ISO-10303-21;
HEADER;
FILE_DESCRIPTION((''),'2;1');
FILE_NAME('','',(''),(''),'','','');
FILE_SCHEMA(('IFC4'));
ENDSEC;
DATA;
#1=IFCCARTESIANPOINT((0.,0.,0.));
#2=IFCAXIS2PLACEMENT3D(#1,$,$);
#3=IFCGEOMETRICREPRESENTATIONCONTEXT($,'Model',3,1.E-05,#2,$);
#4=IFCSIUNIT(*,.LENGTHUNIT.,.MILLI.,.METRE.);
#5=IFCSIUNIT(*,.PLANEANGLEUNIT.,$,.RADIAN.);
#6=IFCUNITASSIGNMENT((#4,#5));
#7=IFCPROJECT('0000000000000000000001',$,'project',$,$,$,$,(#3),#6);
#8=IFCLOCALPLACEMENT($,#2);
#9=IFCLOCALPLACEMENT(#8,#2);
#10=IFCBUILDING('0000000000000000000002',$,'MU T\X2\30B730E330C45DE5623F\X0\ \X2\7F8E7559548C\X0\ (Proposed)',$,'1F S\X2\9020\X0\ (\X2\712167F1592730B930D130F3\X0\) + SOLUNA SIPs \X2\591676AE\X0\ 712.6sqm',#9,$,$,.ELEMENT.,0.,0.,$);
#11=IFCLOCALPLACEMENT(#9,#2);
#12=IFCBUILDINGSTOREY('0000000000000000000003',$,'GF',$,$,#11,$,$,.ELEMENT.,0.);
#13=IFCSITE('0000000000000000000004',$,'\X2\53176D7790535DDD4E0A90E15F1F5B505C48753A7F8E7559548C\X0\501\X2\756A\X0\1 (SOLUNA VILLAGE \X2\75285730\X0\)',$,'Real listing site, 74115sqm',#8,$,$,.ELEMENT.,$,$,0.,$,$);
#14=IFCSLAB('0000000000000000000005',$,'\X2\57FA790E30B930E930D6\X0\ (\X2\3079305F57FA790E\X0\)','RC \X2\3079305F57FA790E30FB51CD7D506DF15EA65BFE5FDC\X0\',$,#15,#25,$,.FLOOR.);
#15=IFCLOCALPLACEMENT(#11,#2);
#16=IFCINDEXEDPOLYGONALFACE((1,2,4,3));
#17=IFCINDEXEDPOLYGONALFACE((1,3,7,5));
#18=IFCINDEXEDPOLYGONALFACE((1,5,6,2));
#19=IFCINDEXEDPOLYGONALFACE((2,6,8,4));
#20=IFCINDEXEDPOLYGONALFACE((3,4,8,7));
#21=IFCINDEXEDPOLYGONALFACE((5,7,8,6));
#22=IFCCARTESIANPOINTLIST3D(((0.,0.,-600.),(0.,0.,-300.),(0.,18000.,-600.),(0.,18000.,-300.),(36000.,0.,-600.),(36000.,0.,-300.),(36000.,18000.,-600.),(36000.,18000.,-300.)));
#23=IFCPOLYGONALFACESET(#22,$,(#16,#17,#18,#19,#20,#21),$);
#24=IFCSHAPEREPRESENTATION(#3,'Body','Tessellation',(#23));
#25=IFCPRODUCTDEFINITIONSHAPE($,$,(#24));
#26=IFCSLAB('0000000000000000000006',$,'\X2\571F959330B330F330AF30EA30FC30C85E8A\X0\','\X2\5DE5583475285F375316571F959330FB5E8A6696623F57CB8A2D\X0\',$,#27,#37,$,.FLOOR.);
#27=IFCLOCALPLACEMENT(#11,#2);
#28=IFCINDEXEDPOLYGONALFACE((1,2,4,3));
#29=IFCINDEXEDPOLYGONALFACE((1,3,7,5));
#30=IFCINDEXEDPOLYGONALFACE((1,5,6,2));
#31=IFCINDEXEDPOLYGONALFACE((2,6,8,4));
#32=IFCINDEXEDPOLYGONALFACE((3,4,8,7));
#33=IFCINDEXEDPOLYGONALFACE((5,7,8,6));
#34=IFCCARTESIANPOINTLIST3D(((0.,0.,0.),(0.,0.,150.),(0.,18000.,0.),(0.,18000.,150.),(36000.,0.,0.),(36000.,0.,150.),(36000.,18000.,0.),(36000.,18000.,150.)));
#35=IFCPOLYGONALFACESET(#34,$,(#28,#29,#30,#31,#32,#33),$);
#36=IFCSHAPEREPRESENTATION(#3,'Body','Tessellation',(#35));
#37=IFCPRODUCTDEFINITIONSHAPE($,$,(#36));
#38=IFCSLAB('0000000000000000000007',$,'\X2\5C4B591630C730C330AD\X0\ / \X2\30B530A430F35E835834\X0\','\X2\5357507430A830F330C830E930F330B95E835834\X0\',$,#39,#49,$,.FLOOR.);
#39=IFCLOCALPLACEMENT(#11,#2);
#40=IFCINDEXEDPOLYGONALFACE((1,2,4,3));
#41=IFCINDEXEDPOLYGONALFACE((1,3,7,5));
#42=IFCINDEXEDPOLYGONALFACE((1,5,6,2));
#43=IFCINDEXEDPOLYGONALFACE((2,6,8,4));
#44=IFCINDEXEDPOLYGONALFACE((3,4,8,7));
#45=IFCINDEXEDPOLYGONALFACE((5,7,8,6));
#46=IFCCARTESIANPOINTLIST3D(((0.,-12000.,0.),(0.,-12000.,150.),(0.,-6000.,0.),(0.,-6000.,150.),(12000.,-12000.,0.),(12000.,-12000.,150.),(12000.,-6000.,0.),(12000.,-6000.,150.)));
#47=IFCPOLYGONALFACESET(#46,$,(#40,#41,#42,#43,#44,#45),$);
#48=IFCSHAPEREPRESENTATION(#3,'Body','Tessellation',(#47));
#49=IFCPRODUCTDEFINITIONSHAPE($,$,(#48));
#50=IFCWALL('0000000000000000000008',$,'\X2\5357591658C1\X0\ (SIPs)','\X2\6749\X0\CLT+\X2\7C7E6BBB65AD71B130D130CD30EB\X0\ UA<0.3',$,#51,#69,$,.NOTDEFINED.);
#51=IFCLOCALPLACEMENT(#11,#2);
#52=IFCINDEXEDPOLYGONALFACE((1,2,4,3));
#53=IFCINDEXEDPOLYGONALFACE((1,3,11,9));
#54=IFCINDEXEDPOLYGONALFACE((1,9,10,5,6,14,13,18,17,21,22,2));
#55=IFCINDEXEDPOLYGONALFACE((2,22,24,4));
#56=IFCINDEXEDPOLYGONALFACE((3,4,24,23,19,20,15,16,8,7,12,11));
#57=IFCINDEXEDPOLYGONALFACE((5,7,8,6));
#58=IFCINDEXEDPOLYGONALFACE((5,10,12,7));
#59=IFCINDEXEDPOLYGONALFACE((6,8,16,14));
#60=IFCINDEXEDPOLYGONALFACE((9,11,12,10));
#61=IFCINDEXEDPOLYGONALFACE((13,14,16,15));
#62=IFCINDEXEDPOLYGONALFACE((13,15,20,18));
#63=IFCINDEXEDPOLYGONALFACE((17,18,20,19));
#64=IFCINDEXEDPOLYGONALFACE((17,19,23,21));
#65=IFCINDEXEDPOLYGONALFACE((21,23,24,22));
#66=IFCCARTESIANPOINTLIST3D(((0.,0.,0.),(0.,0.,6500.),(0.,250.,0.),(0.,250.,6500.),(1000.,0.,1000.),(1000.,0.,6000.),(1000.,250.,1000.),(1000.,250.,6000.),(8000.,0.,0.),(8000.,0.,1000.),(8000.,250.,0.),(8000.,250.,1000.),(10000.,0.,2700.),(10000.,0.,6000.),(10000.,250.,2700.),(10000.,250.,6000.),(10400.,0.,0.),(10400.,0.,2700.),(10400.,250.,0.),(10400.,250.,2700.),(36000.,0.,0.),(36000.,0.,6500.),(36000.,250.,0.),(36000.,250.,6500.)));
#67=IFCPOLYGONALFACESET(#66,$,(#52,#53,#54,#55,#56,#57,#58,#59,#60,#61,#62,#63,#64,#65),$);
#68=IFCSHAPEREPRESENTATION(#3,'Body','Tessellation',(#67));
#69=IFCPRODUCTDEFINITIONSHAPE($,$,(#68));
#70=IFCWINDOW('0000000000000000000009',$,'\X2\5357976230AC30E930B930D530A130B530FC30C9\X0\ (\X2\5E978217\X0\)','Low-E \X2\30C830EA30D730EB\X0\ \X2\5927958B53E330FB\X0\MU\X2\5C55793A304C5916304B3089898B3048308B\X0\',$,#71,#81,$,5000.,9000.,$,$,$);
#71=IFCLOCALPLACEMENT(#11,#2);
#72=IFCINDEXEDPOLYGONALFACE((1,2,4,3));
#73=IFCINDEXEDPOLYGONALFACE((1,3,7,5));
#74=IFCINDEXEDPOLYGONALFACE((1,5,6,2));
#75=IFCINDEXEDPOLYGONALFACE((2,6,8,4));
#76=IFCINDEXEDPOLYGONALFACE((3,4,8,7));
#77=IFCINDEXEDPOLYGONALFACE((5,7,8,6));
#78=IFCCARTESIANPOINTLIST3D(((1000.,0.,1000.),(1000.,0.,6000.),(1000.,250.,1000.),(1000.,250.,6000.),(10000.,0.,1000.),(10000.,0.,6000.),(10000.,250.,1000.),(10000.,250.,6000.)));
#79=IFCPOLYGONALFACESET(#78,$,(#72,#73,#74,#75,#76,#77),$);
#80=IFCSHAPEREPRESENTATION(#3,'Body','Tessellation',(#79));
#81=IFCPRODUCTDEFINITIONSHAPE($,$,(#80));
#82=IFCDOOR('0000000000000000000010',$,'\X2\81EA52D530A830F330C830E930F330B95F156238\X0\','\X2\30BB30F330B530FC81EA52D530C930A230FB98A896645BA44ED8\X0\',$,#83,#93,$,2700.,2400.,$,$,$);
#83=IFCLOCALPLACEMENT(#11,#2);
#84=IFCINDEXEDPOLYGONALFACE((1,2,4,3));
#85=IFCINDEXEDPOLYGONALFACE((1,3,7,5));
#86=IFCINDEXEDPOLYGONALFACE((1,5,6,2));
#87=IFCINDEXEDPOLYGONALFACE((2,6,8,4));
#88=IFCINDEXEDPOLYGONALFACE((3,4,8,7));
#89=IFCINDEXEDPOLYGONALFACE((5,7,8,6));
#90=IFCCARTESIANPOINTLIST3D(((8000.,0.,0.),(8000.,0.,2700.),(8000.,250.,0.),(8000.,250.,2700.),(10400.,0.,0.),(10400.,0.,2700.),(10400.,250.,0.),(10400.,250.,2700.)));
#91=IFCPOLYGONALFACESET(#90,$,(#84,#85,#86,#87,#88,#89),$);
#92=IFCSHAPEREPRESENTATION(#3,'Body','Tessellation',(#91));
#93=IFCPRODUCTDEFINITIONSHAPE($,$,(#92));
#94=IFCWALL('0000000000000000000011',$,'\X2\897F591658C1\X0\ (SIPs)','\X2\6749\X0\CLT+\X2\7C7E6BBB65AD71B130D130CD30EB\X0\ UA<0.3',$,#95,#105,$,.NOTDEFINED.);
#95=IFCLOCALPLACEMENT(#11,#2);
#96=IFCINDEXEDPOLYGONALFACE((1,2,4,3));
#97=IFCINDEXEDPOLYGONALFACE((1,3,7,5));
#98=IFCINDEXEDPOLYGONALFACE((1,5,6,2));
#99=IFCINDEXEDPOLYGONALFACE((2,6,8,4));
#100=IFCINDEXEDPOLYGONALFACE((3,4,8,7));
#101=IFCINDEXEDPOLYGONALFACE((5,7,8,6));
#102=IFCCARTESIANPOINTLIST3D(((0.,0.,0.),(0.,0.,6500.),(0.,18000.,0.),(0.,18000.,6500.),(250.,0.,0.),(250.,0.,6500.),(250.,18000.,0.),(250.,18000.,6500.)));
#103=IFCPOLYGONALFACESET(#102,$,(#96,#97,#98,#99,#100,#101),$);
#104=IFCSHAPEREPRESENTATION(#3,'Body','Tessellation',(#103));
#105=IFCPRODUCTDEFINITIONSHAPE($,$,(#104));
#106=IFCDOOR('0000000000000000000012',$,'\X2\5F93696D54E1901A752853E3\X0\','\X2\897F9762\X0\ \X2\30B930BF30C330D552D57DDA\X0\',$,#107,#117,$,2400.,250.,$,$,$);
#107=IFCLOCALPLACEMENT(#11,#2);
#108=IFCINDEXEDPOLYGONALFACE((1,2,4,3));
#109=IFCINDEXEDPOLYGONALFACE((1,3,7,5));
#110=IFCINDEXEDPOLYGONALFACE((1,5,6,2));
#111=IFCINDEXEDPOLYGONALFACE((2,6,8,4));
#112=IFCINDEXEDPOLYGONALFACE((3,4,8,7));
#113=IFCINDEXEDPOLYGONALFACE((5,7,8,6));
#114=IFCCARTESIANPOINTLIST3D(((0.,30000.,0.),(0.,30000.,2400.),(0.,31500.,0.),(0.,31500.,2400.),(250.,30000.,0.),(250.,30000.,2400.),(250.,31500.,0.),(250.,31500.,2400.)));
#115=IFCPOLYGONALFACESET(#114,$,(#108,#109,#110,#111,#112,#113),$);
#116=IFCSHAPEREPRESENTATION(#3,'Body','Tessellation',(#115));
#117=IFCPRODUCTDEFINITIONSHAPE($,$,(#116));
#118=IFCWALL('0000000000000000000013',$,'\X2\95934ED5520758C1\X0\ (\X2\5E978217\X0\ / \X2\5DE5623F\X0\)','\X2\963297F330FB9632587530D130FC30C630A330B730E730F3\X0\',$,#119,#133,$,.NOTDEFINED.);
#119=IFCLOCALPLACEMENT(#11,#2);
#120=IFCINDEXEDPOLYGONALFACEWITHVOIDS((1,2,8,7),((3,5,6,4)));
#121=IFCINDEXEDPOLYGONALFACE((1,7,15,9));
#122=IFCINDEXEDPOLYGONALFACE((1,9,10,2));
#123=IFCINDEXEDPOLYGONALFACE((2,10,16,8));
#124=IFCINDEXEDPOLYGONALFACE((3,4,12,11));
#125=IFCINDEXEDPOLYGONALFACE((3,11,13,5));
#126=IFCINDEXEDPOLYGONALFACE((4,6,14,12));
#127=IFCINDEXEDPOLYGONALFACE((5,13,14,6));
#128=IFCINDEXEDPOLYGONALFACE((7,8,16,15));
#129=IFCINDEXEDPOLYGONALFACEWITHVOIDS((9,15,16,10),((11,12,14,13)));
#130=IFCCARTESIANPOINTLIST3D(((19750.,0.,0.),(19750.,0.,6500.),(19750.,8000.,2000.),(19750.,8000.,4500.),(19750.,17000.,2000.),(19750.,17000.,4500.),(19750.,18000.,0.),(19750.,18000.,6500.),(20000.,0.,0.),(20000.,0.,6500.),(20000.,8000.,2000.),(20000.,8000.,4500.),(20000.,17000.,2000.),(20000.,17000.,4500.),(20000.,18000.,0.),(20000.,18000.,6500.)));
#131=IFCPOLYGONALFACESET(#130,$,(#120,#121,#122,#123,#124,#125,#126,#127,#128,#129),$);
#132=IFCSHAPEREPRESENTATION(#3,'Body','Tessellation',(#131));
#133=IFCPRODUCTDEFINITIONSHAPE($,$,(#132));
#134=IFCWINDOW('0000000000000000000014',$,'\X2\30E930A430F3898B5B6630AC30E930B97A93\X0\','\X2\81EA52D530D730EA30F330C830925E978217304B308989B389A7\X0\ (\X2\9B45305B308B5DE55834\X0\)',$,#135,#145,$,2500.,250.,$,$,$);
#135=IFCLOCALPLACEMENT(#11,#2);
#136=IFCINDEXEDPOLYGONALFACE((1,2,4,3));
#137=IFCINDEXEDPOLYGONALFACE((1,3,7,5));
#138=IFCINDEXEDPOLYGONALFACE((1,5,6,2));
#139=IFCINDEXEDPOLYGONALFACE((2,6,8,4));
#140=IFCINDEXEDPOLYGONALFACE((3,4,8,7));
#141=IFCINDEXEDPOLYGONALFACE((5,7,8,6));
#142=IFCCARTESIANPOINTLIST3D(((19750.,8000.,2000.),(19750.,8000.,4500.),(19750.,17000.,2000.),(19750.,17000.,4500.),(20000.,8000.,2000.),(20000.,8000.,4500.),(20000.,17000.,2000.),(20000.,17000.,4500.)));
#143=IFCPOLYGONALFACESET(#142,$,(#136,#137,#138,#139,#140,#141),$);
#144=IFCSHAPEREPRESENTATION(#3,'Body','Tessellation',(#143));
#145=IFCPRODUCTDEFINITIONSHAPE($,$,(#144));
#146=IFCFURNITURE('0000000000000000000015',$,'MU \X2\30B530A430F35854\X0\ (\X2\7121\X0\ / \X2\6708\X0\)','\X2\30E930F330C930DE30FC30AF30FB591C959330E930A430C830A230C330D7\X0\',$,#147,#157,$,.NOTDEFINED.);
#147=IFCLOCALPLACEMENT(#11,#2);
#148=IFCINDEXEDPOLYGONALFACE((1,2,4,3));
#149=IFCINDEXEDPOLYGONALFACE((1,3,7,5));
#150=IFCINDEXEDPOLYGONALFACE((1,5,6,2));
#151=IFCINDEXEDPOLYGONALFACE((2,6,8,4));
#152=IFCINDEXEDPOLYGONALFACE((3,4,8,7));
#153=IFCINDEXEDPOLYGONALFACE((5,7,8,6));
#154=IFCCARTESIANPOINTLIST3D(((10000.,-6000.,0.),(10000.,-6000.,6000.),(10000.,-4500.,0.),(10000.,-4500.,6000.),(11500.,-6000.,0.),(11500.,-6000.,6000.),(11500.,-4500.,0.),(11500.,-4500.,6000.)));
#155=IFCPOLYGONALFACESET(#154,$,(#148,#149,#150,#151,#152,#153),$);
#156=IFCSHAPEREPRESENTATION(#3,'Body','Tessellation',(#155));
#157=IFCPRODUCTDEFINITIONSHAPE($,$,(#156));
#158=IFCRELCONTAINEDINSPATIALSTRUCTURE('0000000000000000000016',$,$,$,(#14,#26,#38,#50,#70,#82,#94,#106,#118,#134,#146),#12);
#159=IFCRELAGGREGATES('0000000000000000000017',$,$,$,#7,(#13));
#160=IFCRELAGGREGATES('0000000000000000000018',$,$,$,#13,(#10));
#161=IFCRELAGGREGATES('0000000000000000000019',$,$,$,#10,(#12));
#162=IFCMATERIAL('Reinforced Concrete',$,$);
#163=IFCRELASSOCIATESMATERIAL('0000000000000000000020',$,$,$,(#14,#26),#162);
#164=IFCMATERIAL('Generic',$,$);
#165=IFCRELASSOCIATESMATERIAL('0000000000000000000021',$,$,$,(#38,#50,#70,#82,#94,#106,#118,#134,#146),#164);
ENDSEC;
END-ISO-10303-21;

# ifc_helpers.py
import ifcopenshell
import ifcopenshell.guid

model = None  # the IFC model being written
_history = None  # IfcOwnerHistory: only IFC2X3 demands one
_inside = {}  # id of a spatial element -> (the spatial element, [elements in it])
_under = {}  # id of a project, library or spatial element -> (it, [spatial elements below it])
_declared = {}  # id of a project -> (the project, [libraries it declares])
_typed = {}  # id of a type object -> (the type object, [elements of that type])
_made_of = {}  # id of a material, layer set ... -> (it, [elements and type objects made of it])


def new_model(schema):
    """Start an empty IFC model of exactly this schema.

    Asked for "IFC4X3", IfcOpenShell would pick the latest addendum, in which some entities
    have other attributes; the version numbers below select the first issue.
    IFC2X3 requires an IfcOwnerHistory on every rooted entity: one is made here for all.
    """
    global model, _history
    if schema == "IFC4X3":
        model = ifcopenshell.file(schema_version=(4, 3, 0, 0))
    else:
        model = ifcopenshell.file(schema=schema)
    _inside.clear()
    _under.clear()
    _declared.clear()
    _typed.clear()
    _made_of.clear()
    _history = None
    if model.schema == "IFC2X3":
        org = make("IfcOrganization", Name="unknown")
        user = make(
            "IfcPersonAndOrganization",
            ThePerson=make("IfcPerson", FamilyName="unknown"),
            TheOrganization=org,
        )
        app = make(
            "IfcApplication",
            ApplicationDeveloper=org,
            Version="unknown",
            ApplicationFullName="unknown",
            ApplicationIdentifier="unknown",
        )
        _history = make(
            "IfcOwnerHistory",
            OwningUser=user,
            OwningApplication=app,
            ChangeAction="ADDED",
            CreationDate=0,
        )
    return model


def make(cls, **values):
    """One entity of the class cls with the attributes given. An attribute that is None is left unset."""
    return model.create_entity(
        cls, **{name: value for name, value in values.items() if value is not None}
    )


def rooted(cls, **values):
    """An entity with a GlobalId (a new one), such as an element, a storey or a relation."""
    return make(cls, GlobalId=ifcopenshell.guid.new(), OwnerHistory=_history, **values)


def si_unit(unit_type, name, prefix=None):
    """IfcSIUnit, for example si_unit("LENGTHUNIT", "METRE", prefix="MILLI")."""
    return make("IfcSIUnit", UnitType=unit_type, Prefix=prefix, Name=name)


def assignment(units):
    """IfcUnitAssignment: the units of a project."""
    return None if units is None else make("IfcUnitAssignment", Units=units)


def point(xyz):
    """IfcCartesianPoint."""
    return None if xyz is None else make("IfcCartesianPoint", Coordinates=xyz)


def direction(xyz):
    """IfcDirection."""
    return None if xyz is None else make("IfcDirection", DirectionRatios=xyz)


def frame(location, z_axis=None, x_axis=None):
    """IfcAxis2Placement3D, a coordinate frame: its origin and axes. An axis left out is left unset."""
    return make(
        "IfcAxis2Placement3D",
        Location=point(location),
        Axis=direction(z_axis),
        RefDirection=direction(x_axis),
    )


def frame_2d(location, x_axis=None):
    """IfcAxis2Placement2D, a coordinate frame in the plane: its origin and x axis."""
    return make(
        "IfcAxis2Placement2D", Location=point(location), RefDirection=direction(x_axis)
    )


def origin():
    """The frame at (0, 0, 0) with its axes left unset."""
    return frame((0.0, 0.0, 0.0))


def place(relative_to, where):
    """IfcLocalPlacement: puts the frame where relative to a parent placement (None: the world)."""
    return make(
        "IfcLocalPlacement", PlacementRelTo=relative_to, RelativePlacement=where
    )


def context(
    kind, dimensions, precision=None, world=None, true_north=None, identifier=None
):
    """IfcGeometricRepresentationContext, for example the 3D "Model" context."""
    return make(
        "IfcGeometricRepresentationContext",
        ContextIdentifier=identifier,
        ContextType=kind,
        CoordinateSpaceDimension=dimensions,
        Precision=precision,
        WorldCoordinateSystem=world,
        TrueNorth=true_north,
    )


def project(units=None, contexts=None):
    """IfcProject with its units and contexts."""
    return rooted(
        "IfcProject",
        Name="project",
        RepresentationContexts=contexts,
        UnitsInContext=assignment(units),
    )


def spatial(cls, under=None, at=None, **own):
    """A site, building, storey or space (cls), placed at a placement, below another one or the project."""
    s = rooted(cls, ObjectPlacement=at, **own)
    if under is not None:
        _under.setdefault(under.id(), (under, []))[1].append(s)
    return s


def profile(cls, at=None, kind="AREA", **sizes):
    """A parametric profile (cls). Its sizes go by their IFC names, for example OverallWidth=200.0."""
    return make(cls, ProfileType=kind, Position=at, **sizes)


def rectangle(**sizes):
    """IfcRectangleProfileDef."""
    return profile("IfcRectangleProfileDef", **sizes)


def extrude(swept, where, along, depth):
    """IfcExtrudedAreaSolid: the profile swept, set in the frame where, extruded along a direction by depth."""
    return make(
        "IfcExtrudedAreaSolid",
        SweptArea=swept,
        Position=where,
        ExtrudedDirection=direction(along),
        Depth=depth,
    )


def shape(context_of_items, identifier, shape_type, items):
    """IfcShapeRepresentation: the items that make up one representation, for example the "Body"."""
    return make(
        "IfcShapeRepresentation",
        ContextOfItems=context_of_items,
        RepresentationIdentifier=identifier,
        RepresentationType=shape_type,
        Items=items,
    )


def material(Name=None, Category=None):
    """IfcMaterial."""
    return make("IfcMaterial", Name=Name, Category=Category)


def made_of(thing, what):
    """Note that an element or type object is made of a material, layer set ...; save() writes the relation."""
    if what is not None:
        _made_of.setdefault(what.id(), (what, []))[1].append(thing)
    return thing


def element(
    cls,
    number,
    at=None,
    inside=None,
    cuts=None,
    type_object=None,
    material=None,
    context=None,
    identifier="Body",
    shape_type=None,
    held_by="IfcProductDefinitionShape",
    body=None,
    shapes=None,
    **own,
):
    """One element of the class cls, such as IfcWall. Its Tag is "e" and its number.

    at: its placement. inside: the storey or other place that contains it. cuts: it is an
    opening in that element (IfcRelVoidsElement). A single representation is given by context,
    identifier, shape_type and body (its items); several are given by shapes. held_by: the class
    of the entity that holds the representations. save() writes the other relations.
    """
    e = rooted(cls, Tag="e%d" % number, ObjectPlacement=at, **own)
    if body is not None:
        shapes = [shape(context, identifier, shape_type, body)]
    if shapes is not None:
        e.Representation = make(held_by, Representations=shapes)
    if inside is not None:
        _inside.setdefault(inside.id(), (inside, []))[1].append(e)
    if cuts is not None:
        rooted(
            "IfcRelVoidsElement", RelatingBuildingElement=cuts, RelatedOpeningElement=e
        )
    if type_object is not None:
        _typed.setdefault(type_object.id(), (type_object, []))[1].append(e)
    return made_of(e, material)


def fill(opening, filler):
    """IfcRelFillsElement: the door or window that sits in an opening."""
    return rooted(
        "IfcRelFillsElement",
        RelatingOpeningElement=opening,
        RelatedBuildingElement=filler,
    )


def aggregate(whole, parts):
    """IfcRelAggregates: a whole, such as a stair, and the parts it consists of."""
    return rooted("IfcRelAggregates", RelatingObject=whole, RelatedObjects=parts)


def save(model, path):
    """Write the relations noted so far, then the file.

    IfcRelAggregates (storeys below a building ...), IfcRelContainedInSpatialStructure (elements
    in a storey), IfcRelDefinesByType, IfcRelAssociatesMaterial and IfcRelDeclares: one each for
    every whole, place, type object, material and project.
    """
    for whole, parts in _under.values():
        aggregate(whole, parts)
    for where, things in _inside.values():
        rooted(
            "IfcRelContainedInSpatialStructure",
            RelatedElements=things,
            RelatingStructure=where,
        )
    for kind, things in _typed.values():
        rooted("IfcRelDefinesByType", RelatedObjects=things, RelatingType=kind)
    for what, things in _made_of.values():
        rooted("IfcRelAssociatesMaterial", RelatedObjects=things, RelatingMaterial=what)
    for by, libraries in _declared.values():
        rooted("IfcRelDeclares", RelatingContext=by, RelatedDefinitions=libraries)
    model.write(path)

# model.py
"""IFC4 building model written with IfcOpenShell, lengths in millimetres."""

from ifc_helpers import new_model, si_unit, frame, frame_2d, origin, place, context, project, spatial, rectangle, extrude, material, element, fill, save


model = new_model("IFC4")

# Units and contexts
model_context = context("Model", 3, precision=1e-05, world=origin())
ifc_project = project(units=[si_unit("LENGTHUNIT", "METRE", prefix="MILLI"), si_unit("PLANEANGLEUNIT", "RADIAN")], contexts=[model_context])

# Site, building, storey
site_placement = place(None, origin())
site = spatial("IfcSite", under=ifc_project, at=site_placement, Name="北海道川上郡弟子屈町美留和501番1 (SOLUNA VILLAGE 用地)", ObjectType="Real listing site, 74115sqm", CompositionType="ELEMENT", RefElevation=0.0)
building_placement = place(site_placement, origin())
building = spatial("IfcBuilding", under=site, at=building_placement, Name="MU Tシャツ工房 美留和 (Proposed)", ObjectType="1F S造 (無柱大スパン) + SOLUNA SIPs 外皮 712.6sqm", CompositionType="ELEMENT", ElevationOfRefHeight=0.0, ElevationOfTerrain=0.0)
storey_placement = place(building_placement, origin())
storey = spatial("IfcBuildingStorey", under=building, at=storey_placement, Name="GF", CompositionType="ELEMENT", Elevation=0.0)

# Slabs
ifc_material_1 = material(Name="Reinforced Concrete")
slab_1_placement = place(storey_placement, frame((0.0, 0.0, -300.0)))
element("IfcSlab", 1, at=slab_1_placement, inside=storey, material=ifc_material_1, Name="基礎スラブ (べた基礎)", Description="RC べた基礎・凍結深度対応", PredefinedType="FLOOR", context=model_context, shape_type="SweptSolid", body=[
    extrude(rectangle(XDim=36000.0, YDim=18000.0, at=frame_2d((18000.0, 9000.0))), frame((0.0, 0.0, -300.0)), (0.0, 0.0, 1.0), 300.0),
])
slab_2_placement = place(storey_placement, origin())
element("IfcSlab", 2, at=slab_2_placement, inside=storey, material=ifc_material_1, Name="土間コンクリート床", Description="工場用強化土間・床暖房埋設", PredefinedType="FLOOR", context=model_context, shape_type="SweptSolid", body=[
    extrude(rectangle(XDim=36000.0, YDim=18000.0, at=frame_2d((18000.0, 9000.0))), origin(), (0.0, 0.0, 1.0), 150.0),
])
ifc_material_2 = material(Name="Generic")
slab_3_placement = place(storey_placement, frame((0.0, -6000.0, 0.0)))
element("IfcSlab", 3, at=slab_3_placement, inside=storey, material=ifc_material_2, Name="屋外デッキ / サイン広場", Description="南側エントランス広場", PredefinedType="FLOOR", context=model_context, shape_type="SweptSolid", body=[
    extrude(rectangle(XDim=12000.0, YDim=6000.0, at=frame_2d((6000.0, 3000.0))), frame((0.0, -6000.0, 0.0)), (0.0, 0.0, 1.0), 150.0),
])

# Wall, openings, window, door
wall_1_placement = place(storey_placement, origin())
wall_1 = element("IfcWall", 4, at=wall_1_placement, inside=storey, material=ifc_material_2, Name="南外壁 (SIPs)", Description="杉CLT+籾殻断熱パネル UA<0.3", PredefinedType="NOTDEFINED", context=model_context, shape_type="SweptSolid", body=[
    extrude(rectangle(XDim=36000.0, YDim=250.0, at=frame_2d((18000.0, 125.0))), origin(), (0.0, 0.0, 1.0), 6500.0),
])
opening_1_placement = place(storey_placement, frame((500.0, 0.0, 500.0)))
opening_1 = element("IfcOpeningElement", 5, at=opening_1_placement, cuts=wall_1, PredefinedType="NOTDEFINED", context=model_context, shape_type="SweptSolid", body=[
    extrude(rectangle(XDim=9000.0, YDim=250.0, at=frame_2d((4500.0, 125.0))), frame((500.0, 0.0, 500.0)), (0.0, 0.0, 1.0), 5000.0),
])
opening_2_placement = place(storey_placement, frame((4000.0, 0.0, 0.0)))
opening_2 = element("IfcOpeningElement", 6, at=opening_2_placement, cuts=wall_1, PredefinedType="NOTDEFINED", context=model_context, shape_type="SweptSolid", body=[
    extrude(rectangle(XDim=2400.0, YDim=250.0, at=frame_2d((1200.0, 125.0))), frame((4000.0, 0.0, 0.0)), (0.0, 0.0, 1.0), 2700.0),
])
window_1_placement = place(storey_placement, frame((500.0, 0.0, 500.0)))
window_1 = element("IfcWindow", 7, at=window_1_placement, inside=storey, material=ifc_material_2, Name="南面ガラスファサード (店舗)", Description="Low-E トリプル 大開口・MU展示が外から見える", OverallHeight=5000.0, OverallWidth=9000.0, context=model_context, shape_type="SweptSolid", body=[
    extrude(rectangle(XDim=9000.0, YDim=250.0, at=frame_2d((4500.0, 125.0))), frame((500.0, 0.0, 500.0)), (0.0, 0.0, 1.0), 5000.0),
])
fill(opening_1, window_1)
door_1_placement = place(storey_placement, frame((4000.0, 0.0, 0.0)))
door_1 = element("IfcDoor", 8, at=door_1_placement, inside=storey, material=ifc_material_2, Name="自動エントランス引戸", Description="センサー自動ドア・風除室付", OverallHeight=2700.0, OverallWidth=2400.0, context=model_context, shape_type="SweptSolid", body=[
    extrude(rectangle(XDim=2400.0, YDim=250.0, at=frame_2d((1200.0, 125.0))), frame((4000.0, 0.0, 0.0)), (0.0, 0.0, 1.0), 2700.0),
])
fill(opening_2, door_1)

# Wall, opening, door
wall_2_placement = place(storey_placement, origin())
wall_2 = element("IfcWall", 9, at=wall_2_placement, inside=storey, material=ifc_material_2, Name="西外壁 (SIPs)", Description="杉CLT+籾殻断熱パネル UA<0.3", PredefinedType="NOTDEFINED", context=model_context, shape_type="SweptSolid", body=[
    extrude(rectangle(XDim=250.0, YDim=18000.0, at=frame_2d((125.0, 9000.0))), origin(), (0.0, 0.0, 1.0), 6500.0),
])
opening_3_placement = place(storey_placement, frame((0.0, 15000.0, 0.0)))
opening_3 = element("IfcOpeningElement", 10, at=opening_3_placement, cuts=wall_2, PredefinedType="NOTDEFINED", context=model_context, shape_type="SweptSolid", body=[
    extrude(rectangle(XDim=250.0, YDim=1500.0, at=frame_2d((125.0, 750.0))), frame((0.0, 15000.0, 0.0)), (0.0, 0.0, 1.0), 2400.0),
])
door_2_placement = place(storey_placement, frame((0.0, 15000.0, 0.0)))
door_2 = element("IfcDoor", 11, at=door_2_placement, inside=storey, material=ifc_material_2, Name="従業員通用口", Description="西面 スタッフ動線", OverallHeight=2400.0, OverallWidth=250.0, context=model_context, shape_type="SweptSolid", body=[
    extrude(rectangle(XDim=250.0, YDim=1500.0, at=frame_2d((125.0, 750.0))), frame((0.0, 15000.0, 0.0)), (0.0, 0.0, 1.0), 2400.0),
])
fill(opening_3, door_2)

# Wall, opening, window
wall_3_placement = place(storey_placement, frame((9875.0, 0.0, 0.0)))
wall_3 = element("IfcWall", 12, at=wall_3_placement, inside=storey, material=ifc_material_2, Name="間仕切壁 (店舗 / 工房)", Description="防音・防塵パーティション", PredefinedType="NOTDEFINED", context=model_context, shape_type="SweptSolid", body=[
    extrude(rectangle(XDim=250.0, YDim=18000.0, at=frame_2d((125.0, 9000.0))), frame((9875.0, 0.0, 0.0)), (0.0, 0.0, 1.0), 6500.0),
])
opening_4_placement = place(storey_placement, frame((9875.0, 4000.0, 1000.0)))
opening_4 = element("IfcOpeningElement", 13, at=opening_4_placement, cuts=wall_3, PredefinedType="NOTDEFINED", context=model_context, shape_type="SweptSolid", body=[
    extrude(rectangle(XDim=250.0, YDim=9000.0, at=frame_2d((125.0, 4500.0))), frame((9875.0, 4000.0, 1000.0)), (0.0, 0.0, 1.0), 2500.0),
])
window_2_placement = place(storey_placement, frame((9875.0, 4000.0, 1000.0)))
window_2 = element("IfcWindow", 14, at=window_2_placement, inside=storey, material=ifc_material_2, Name="ライン見学ガラス窓", Description="自動プリントを店舗から観覧 (魅せる工場)", OverallHeight=2500.0, OverallWidth=250.0, context=model_context, shape_type="SweptSolid", body=[
    extrude(rectangle(XDim=250.0, YDim=9000.0, at=frame_2d((125.0, 4500.0))), frame((9875.0, 4000.0, 1000.0)), (0.0, 0.0, 1.0), 2500.0),
])
fill(opening_4, window_2)

# Furniture
furniture_1_placement = place(storey_placement, frame((5000.0, -3000.0, 0.0)))
element("IfcFurniture", 15, at=furniture_1_placement, inside=storey, material=ifc_material_2, Name="MU サイン塔 (無 / 月)", Description="ランドマーク・夜間ライトアップ", PredefinedType="NOTDEFINED", context=model_context, shape_type="SweptSolid", body=[
    extrude(rectangle(XDim=1500.0, YDim=1500.0, at=frame_2d((750.0, 750.0))), frame((5000.0, -3000.0, 0.0)), (0.0, 0.0, 1.0), 6000.0),
])

save(model, "model.ifc")
